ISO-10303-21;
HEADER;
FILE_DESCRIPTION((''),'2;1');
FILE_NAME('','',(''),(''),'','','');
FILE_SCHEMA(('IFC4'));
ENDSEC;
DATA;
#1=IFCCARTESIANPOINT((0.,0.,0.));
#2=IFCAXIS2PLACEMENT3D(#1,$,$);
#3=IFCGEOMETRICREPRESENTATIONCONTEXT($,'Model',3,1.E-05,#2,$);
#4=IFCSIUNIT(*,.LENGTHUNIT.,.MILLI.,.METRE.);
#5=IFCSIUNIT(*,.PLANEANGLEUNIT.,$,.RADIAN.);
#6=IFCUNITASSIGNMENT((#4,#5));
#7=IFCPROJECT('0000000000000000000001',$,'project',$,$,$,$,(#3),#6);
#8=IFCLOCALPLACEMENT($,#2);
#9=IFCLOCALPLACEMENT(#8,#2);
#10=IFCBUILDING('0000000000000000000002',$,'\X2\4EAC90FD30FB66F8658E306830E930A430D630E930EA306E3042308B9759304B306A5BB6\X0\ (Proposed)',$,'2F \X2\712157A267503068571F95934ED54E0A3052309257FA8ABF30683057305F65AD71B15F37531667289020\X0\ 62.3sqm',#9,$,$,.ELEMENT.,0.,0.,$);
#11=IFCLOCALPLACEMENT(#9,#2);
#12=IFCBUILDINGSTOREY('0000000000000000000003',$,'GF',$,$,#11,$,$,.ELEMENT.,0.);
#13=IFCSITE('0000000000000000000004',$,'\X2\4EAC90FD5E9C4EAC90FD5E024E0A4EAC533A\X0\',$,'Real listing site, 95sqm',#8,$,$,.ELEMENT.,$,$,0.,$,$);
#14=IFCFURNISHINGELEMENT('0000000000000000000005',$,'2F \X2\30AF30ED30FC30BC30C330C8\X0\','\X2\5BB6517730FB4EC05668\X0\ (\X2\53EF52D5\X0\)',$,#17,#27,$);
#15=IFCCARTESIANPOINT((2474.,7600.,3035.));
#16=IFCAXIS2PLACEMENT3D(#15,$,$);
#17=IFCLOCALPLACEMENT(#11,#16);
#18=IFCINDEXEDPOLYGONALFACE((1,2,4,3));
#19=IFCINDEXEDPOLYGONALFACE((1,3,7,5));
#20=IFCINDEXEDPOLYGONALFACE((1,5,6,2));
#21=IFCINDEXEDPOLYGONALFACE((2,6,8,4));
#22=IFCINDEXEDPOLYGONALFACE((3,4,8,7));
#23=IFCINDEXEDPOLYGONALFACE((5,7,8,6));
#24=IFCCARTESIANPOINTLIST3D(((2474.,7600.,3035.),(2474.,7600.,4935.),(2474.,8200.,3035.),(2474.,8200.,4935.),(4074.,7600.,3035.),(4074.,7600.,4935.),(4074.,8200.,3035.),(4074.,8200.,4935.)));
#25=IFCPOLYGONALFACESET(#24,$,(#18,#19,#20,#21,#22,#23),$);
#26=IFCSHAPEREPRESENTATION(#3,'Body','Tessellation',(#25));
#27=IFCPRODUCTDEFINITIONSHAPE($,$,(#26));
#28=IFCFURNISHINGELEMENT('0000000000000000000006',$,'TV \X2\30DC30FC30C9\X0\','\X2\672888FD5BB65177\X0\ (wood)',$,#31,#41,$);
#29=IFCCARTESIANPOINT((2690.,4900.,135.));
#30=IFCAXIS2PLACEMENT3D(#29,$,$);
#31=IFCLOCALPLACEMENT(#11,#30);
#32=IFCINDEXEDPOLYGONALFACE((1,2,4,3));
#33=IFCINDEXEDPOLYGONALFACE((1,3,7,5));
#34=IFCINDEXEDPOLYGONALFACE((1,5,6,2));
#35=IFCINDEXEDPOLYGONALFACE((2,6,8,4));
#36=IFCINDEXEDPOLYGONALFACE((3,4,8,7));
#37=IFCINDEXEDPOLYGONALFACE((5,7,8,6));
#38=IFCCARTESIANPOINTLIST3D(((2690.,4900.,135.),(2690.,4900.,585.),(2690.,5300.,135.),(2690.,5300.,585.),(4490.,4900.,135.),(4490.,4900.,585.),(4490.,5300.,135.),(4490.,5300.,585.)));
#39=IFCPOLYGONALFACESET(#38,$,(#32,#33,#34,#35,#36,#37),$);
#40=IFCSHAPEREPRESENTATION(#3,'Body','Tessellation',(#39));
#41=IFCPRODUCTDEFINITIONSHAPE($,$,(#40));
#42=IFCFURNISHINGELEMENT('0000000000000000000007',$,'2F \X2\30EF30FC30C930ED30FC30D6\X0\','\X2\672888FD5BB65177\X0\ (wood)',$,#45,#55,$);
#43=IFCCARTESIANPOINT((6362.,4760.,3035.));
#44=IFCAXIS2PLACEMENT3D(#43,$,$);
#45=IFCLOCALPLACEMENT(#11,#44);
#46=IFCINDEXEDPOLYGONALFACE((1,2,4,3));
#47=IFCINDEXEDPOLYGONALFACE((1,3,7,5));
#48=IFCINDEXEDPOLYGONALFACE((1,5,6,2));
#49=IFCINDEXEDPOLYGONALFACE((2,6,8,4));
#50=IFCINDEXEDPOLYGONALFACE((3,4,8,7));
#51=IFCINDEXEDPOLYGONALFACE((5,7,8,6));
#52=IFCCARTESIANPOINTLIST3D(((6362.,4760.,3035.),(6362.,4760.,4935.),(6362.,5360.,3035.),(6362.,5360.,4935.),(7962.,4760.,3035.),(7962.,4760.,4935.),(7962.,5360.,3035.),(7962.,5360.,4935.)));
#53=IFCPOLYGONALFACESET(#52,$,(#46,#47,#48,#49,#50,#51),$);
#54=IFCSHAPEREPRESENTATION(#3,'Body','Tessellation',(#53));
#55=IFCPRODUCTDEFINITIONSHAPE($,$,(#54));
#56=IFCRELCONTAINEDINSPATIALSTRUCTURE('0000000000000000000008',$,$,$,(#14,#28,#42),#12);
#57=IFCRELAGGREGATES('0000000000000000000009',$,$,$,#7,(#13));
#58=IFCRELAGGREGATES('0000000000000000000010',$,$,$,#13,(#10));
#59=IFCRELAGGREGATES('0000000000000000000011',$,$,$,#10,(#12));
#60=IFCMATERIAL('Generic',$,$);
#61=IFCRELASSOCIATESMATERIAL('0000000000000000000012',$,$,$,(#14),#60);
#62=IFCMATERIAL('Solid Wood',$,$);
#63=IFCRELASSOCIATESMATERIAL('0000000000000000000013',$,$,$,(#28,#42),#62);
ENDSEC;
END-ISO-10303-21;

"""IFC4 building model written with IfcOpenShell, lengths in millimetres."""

from ifc_helpers import new_model, si_unit, frame, frame_2d, origin, place, context, project, spatial, rectangle, extrude, material, element, save


model = new_model("IFC4")

# Units and contexts
model_context = context("Model", 3, precision=1e-05, world=origin())
ifc_project = project(units=[si_unit("LENGTHUNIT", "METRE", prefix="MILLI"), si_unit("PLANEANGLEUNIT", "RADIAN")], contexts=[model_context])

# Site, building, storey
site_placement = place(None, origin())
site = spatial("IfcSite", under=ifc_project, at=site_placement, Name="京都府京都市上京区", ObjectType="Real listing site, 95sqm", CompositionType="ELEMENT", RefElevation=0.0)
building_placement = place(site_placement, origin())
building = spatial("IfcBuilding", under=site, at=building_placement, Name="京都・書斎とライブラリのある静かな家 (Proposed)", ObjectType="2F 無垢材と土間仕上げを基調とした断熱強化木造 62.3sqm", CompositionType="ELEMENT", ElevationOfRefHeight=0.0, ElevationOfTerrain=0.0)
storey_placement = place(building_placement, origin())
storey = spatial("IfcBuildingStorey", under=building, at=storey_placement, Name="GF", CompositionType="ELEMENT", Elevation=0.0)

# Shared definitions
ifc_material_1 = material(Name="Solid Wood")

# Shared definitions
ifc_material_2 = material(Name="Generic")

# Furnishing elements
furnishing_1_placement = place(storey_placement, frame((2474.0, 7600.0, 3035.0)))
element("IfcFurnishingElement", 1, at=furnishing_1_placement, inside=storey, material=ifc_material_2, Name="2F クローゼット", Description="家具・什器 (可動)", context=model_context, shape_type="SweptSolid", body=[
    extrude(rectangle(XDim=1600.0, YDim=600.0, at=frame_2d((800.0, 300.0))), frame((2474.0, 7600.0, 3035.0)), (0.0, 0.0, 1.0), 1900.0),
])
furnishing_2_placement = place(storey_placement, frame((2690.0, 4900.0, 135.0)))
element("IfcFurnishingElement", 2, at=furnishing_2_placement, inside=storey, material=ifc_material_1, Name="TV ボード", Description="木製家具 (wood)", context=model_context, shape_type="SweptSolid", body=[
    extrude(rectangle(XDim=1800.0, YDim=400.0, at=frame_2d((900.0, 200.0))), frame((2690.0, 4900.0, 135.0)), (0.0, 0.0, 1.0), 450.0),
])
furnishing_3_placement = place(storey_placement, frame((6362.0, 4760.0, 3035.0)))
element("IfcFurnishingElement", 3, at=furnishing_3_placement, inside=storey, material=ifc_material_1, Name="2F ワードローブ", Description="木製家具 (wood)", context=model_context, shape_type="SweptSolid", body=[
    extrude(rectangle(XDim=1600.0, YDim=600.0, at=frame_2d((800.0, 300.0))), frame((6362.0, 4760.0, 3035.0)), (0.0, 0.0, 1.0), 1900.0),
])

save(model, "model.ifc")
